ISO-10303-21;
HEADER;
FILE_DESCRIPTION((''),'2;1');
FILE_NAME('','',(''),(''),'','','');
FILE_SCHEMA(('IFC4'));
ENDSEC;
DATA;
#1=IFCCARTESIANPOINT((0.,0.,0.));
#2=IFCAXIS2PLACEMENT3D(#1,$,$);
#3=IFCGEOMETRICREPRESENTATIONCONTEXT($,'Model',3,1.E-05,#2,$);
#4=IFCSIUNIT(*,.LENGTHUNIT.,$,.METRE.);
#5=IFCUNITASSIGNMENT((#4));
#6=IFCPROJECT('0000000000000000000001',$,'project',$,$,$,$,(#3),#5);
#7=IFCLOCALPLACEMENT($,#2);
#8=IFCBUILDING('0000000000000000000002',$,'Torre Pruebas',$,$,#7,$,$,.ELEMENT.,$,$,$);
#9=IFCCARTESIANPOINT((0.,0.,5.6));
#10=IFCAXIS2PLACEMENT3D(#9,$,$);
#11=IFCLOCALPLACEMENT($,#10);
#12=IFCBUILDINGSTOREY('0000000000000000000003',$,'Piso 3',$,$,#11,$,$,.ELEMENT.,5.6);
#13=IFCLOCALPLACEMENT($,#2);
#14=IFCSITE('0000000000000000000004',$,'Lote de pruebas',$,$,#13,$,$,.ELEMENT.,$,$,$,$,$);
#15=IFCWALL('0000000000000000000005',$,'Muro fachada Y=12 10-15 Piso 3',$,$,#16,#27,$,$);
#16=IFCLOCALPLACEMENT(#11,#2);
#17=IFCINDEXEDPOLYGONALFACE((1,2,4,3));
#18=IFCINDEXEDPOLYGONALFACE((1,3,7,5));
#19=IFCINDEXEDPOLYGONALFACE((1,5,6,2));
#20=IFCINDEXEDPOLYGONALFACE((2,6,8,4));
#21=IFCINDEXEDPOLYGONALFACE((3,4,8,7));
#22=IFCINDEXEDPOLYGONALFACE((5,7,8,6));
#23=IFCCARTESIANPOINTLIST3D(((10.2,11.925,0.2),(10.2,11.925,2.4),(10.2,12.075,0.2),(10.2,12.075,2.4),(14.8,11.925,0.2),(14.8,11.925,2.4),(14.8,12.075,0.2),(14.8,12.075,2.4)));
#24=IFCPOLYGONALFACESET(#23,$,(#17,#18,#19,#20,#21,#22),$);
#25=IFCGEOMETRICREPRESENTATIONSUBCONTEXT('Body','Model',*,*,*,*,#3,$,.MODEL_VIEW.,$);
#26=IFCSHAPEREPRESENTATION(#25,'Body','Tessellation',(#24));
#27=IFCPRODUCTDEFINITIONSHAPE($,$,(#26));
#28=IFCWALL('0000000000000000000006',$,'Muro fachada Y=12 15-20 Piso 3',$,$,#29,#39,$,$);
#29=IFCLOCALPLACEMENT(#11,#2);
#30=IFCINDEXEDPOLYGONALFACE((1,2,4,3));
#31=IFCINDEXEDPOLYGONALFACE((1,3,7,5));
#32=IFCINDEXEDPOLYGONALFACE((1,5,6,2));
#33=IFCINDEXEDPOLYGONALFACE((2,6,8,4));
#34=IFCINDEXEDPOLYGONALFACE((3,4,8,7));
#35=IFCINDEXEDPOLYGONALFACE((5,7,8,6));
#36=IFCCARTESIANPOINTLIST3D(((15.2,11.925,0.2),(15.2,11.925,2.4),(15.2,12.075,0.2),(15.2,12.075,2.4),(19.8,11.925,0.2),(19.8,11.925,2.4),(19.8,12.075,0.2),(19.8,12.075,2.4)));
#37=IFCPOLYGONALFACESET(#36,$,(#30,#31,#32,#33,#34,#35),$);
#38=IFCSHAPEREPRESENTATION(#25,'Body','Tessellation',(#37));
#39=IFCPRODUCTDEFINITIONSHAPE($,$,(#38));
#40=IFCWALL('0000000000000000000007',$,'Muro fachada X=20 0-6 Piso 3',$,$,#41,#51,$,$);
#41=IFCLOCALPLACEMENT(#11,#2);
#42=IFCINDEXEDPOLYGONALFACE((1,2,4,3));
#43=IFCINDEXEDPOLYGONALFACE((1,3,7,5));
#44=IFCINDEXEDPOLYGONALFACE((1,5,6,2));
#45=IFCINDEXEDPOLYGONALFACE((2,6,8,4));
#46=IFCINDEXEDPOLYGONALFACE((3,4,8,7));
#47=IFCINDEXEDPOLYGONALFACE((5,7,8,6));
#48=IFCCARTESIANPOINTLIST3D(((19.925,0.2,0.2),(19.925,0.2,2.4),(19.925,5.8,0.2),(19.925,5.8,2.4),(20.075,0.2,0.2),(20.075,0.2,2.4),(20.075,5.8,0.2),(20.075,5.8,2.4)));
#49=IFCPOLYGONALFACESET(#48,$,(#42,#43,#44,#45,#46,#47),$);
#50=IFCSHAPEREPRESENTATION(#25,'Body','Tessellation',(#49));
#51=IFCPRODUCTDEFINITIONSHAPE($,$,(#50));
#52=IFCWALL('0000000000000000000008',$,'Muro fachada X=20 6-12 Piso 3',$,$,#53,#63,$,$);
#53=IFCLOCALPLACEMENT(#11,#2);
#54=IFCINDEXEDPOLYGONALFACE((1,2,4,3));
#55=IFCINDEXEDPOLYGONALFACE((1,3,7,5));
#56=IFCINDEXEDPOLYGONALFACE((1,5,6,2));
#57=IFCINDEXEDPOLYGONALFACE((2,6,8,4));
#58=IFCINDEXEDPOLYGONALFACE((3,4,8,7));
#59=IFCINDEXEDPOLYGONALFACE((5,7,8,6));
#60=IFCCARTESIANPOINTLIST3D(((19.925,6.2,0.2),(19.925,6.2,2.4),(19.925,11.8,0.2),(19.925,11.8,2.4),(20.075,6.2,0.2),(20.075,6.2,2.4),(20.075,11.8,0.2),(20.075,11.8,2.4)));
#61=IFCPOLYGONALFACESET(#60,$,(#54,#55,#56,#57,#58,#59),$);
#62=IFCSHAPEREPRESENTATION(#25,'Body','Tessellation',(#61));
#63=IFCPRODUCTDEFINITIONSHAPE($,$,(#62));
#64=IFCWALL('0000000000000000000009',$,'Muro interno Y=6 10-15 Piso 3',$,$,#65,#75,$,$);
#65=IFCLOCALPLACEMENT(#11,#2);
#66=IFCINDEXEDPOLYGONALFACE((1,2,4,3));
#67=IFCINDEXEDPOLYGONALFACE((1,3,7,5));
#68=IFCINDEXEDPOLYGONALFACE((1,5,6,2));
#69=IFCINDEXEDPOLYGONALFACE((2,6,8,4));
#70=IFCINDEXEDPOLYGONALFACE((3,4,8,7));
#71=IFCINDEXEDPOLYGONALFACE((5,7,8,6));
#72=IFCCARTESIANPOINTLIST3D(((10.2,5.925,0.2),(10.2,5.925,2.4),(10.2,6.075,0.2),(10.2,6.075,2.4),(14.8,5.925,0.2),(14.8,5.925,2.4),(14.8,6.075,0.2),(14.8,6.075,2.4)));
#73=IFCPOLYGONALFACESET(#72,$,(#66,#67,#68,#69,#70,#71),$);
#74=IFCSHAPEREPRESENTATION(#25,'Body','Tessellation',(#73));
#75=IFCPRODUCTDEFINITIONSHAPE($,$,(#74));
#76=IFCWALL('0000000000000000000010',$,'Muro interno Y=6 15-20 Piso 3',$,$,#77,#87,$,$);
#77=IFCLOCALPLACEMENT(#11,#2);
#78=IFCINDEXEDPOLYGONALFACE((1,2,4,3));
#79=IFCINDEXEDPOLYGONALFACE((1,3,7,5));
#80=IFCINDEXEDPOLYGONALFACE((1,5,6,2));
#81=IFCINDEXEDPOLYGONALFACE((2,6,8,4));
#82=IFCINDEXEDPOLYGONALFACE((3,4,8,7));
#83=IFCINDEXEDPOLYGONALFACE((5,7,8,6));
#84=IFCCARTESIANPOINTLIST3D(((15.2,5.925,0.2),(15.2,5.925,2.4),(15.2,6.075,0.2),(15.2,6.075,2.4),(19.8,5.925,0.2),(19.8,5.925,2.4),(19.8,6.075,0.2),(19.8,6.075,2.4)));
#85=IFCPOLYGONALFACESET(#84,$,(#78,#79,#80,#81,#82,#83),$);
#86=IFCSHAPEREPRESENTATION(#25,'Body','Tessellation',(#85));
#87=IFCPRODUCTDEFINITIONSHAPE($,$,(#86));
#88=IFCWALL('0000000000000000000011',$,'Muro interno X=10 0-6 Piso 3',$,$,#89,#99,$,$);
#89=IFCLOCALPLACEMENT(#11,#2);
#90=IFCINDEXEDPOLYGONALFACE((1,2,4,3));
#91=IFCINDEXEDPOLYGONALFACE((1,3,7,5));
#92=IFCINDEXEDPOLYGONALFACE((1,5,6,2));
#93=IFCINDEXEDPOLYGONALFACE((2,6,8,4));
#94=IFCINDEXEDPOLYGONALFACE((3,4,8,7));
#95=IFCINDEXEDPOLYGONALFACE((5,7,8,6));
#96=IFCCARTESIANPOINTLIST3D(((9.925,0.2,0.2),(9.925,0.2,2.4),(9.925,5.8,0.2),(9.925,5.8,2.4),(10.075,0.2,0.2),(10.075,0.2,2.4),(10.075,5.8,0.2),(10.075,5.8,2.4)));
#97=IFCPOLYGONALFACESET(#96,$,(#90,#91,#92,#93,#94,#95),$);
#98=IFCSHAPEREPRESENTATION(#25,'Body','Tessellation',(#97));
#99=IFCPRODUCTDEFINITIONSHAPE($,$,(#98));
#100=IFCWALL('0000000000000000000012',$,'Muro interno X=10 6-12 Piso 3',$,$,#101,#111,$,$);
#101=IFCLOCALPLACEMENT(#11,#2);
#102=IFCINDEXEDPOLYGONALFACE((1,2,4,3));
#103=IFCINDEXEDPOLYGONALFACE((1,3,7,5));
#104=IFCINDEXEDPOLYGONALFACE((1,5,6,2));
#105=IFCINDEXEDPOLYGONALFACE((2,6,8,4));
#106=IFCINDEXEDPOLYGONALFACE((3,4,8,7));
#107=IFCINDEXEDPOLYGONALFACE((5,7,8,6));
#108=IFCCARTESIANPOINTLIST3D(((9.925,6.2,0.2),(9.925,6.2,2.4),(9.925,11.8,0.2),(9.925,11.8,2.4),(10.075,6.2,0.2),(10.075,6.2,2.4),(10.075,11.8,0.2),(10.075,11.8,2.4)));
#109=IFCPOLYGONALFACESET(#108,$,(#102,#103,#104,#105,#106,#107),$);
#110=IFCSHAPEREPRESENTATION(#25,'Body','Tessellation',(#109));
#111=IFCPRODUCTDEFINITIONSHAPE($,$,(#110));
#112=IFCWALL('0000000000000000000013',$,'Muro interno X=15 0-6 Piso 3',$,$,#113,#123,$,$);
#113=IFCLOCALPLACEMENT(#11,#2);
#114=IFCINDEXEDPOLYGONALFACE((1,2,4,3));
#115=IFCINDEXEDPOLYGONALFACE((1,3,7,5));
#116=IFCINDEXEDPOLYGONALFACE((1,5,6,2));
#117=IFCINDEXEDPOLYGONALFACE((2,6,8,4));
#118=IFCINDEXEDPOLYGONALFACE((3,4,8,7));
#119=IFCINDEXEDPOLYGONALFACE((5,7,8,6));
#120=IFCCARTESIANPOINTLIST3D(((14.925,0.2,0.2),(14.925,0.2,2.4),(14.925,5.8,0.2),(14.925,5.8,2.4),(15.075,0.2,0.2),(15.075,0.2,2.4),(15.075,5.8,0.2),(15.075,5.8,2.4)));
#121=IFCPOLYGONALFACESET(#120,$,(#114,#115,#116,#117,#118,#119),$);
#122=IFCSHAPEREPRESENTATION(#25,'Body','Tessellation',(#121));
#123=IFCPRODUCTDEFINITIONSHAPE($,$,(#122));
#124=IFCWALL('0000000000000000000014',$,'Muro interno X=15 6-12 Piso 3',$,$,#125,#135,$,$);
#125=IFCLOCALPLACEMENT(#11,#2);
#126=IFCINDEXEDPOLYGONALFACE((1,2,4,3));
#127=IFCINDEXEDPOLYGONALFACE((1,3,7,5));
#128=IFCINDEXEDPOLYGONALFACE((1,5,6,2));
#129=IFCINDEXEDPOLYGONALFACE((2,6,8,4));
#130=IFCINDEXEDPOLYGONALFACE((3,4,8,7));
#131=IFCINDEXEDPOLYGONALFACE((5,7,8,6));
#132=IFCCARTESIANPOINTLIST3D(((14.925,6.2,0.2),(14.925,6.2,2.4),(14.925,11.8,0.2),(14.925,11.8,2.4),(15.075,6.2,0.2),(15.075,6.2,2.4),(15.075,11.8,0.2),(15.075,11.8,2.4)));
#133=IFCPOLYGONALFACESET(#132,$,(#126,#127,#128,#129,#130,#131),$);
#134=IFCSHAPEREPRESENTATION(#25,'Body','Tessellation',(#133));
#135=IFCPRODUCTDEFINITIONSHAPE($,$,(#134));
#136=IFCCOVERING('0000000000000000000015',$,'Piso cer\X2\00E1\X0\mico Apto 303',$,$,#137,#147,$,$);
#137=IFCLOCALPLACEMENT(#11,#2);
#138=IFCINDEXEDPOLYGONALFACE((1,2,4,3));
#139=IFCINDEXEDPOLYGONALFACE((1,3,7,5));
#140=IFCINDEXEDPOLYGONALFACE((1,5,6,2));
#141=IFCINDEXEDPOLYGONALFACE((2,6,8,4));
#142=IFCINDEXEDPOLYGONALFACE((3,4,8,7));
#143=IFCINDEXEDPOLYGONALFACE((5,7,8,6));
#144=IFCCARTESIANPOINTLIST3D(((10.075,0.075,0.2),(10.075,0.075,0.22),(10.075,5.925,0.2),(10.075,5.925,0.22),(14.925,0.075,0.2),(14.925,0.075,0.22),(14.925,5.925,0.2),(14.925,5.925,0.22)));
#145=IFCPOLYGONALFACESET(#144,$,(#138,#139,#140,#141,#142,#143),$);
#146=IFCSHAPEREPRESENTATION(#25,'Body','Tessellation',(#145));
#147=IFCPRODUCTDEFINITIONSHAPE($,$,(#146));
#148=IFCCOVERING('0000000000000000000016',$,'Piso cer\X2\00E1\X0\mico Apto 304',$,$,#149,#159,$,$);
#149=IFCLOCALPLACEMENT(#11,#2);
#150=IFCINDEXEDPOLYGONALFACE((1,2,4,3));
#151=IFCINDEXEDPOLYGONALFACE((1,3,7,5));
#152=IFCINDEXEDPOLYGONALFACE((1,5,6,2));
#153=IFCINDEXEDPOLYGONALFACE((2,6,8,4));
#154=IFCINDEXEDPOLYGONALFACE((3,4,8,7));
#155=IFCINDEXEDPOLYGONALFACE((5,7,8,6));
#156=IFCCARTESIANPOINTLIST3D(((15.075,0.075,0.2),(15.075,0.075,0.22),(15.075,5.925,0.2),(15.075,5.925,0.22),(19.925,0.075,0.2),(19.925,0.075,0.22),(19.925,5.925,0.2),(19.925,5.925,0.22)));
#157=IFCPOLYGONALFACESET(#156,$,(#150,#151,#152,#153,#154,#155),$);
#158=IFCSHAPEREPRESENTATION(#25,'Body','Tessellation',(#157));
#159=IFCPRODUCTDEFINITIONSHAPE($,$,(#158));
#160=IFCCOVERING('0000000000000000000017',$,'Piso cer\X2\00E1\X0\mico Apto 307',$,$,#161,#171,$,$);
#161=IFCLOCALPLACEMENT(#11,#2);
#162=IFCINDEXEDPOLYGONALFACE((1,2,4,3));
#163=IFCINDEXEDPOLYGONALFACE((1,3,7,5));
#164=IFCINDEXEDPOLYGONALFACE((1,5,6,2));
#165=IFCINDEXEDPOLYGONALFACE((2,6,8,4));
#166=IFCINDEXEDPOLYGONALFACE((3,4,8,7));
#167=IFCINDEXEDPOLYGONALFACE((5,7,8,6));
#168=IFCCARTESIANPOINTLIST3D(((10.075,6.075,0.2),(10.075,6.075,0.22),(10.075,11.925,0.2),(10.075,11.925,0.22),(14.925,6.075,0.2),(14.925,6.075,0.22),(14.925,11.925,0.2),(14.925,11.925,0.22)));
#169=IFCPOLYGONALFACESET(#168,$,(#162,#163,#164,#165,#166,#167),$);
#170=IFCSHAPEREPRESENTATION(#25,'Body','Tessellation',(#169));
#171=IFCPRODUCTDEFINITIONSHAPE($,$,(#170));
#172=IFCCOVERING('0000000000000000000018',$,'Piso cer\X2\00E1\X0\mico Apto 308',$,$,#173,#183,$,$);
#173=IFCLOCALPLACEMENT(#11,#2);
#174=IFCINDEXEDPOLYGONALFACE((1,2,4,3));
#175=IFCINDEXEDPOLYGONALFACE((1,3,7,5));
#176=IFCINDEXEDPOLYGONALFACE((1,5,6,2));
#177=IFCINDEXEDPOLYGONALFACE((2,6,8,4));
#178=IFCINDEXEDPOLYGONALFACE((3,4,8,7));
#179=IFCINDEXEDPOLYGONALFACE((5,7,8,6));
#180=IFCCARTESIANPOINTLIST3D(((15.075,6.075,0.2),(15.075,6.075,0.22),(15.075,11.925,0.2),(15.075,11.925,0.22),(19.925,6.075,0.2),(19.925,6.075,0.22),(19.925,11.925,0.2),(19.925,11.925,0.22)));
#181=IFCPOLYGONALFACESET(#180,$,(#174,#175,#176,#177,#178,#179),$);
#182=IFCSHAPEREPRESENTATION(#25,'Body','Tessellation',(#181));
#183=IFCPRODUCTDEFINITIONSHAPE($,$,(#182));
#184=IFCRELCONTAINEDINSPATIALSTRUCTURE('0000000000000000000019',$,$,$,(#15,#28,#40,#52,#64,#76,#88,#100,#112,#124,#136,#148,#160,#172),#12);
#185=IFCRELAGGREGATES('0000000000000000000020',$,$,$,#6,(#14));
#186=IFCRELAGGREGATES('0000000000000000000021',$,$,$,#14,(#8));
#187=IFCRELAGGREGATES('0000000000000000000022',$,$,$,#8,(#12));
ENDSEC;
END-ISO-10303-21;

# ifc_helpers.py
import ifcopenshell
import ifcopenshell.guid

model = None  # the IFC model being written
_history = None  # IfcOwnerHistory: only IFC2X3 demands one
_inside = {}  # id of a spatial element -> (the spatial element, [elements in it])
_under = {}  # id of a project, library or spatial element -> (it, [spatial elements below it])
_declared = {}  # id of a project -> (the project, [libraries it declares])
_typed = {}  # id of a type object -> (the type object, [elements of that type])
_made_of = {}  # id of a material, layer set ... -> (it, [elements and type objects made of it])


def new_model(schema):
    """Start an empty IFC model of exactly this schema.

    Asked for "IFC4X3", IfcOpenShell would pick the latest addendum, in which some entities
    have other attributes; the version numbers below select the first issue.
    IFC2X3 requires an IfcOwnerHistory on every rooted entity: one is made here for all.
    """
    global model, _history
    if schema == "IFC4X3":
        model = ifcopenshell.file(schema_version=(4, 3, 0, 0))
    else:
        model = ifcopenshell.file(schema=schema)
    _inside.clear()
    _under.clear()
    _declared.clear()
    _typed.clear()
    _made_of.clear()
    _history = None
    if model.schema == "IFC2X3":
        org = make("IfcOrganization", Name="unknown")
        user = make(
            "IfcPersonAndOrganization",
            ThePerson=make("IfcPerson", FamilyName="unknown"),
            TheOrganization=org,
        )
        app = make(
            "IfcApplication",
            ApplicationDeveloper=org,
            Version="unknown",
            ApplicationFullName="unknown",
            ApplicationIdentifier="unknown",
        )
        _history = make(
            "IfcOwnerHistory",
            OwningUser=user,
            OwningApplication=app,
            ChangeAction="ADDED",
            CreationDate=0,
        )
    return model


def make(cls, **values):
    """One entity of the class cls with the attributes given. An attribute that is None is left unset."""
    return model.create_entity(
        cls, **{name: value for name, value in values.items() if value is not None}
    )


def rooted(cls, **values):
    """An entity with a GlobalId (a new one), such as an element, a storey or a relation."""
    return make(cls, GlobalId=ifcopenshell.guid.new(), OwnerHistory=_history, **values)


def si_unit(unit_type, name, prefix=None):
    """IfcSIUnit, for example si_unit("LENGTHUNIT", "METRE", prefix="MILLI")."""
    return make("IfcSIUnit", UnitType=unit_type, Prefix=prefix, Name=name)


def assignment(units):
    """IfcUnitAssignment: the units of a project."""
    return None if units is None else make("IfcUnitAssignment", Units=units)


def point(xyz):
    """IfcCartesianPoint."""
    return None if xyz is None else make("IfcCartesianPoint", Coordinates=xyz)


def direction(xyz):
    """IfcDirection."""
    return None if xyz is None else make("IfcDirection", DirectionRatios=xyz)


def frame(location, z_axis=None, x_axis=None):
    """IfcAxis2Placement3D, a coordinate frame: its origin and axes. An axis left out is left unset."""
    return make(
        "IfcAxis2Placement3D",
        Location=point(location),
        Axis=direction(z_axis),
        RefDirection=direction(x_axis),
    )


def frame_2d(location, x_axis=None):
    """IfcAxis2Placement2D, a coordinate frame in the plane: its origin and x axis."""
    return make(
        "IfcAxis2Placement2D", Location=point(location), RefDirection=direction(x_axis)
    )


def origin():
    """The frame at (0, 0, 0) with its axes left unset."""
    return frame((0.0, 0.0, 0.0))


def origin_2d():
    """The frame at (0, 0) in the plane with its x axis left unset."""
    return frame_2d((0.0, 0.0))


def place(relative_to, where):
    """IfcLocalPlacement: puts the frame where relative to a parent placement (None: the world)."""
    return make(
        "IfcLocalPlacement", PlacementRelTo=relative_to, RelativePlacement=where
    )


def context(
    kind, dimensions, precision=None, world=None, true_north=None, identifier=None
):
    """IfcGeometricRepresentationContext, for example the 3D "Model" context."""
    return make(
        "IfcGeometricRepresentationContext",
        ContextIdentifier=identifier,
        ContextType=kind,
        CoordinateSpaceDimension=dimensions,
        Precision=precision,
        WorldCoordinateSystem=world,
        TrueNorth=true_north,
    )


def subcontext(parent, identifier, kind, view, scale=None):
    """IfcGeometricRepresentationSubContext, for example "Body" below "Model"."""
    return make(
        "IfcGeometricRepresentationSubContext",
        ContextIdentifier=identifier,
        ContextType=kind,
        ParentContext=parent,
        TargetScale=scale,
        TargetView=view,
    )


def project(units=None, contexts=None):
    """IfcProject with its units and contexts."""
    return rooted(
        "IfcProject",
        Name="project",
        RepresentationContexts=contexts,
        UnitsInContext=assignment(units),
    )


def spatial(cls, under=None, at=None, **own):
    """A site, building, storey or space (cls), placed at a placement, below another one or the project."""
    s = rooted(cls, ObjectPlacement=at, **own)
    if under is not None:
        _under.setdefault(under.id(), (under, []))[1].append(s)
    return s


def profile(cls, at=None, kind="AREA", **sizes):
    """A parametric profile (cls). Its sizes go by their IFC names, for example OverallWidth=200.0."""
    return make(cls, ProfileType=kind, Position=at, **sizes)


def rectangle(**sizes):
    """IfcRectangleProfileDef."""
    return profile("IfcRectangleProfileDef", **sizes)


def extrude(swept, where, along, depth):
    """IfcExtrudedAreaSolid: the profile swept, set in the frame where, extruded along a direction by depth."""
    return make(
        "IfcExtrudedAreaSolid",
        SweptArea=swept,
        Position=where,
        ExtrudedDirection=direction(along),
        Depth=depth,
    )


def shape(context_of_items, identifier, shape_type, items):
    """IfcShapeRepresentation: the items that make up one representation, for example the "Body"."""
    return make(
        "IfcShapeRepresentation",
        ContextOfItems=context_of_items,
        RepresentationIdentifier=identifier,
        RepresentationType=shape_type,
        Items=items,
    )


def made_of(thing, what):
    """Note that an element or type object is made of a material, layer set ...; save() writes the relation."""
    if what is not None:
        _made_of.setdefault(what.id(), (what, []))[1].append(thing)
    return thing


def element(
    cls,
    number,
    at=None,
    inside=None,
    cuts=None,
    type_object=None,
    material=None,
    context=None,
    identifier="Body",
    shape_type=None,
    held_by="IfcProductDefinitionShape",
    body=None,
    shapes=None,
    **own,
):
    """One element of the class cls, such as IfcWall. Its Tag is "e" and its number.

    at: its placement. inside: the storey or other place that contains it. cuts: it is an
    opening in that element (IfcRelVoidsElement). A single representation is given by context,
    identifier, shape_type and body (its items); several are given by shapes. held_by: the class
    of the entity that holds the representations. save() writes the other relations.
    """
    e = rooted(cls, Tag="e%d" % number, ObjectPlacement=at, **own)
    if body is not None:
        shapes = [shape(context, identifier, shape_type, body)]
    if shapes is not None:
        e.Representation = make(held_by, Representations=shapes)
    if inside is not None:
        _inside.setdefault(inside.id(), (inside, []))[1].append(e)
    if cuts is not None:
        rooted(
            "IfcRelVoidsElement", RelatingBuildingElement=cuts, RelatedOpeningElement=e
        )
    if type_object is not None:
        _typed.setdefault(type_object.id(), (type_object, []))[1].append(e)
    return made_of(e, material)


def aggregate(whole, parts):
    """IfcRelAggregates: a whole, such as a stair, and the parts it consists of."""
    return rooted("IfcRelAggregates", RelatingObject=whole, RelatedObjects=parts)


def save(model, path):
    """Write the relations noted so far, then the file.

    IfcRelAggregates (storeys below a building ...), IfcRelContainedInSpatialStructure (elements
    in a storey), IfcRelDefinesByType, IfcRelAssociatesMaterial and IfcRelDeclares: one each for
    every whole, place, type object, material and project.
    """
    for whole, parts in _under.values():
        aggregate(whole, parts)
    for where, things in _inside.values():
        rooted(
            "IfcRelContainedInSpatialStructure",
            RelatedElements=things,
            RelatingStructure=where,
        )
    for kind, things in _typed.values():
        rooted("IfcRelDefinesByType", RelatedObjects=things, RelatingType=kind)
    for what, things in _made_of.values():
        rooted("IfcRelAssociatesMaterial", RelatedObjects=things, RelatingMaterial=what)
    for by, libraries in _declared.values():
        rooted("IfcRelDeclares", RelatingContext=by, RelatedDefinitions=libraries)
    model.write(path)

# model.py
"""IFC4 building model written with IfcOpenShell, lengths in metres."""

from ifc_helpers import new_model, si_unit, frame, origin, origin_2d, place, context, subcontext, project, spatial, rectangle, extrude, element, save


model = new_model("IFC4")

# Units and contexts
model_context = context("Model", 3, precision=1e-05, world=origin())
body_context = subcontext(model_context, "Body", "Model", "MODEL_VIEW")
ifc_project = project(units=[si_unit("LENGTHUNIT", "METRE")], contexts=[model_context])

# Site, building, storey
site_placement = place(None, origin())
site = spatial("IfcSite", under=ifc_project, at=site_placement, Name="Lote de pruebas", CompositionType="ELEMENT")
building_placement = place(None, origin())
building = spatial("IfcBuilding", under=site, at=building_placement, Name="Torre Pruebas", CompositionType="ELEMENT")
storey_placement = place(None, frame((0.0, 0.0, 5.6)))
storey = spatial("IfcBuildingStorey", under=building, at=storey_placement, Name="Piso 3", CompositionType="ELEMENT", Elevation=5.6)

# Walls
for number, where, name in (
    (1, (12.5, 12.0, 5.8), "Muro fachada Y=12 10-15 Piso 3"),
    (2, (17.5, 12.0, 5.8), "Muro fachada Y=12 15-20 Piso 3"),
):
    element("IfcWall", number, at=place(None, frame(where)), inside=storey, Name=name, context=body_context, shape_type="SweptSolid", body=[
        extrude(rectangle(XDim=4.6, YDim=0.15, at=origin_2d()), origin(), (0.0, 0.0, 1.0), 2.2),
    ])
for number, where, name in (
    (3, (20.0, 3.0, 5.8), "Muro fachada X=20 0-6 Piso 3"),
    (4, (20.0, 9.0, 5.8), "Muro fachada X=20 6-12 Piso 3"),
):
    element("IfcWall", number, at=place(None, frame(where)), inside=storey, Name=name, context=body_context, shape_type="SweptSolid", body=[
        extrude(rectangle(XDim=0.15, YDim=5.6, at=origin_2d()), origin(), (0.0, 0.0, 1.0), 2.2),
    ])
for number, where, name in (
    (5, (12.5, 6.0, 5.8), "Muro interno Y=6 10-15 Piso 3"),
    (6, (17.5, 6.0, 5.8), "Muro interno Y=6 15-20 Piso 3"),
):
    element("IfcWall", number, at=place(None, frame(where)), inside=storey, Name=name, context=body_context, shape_type="SweptSolid", body=[
        extrude(rectangle(XDim=4.6, YDim=0.15, at=origin_2d()), origin(), (0.0, 0.0, 1.0), 2.2),
    ])
for number, where, name in (
    (7, (10.0, 3.0, 5.8), "Muro interno X=10 0-6 Piso 3"),
    (8, (10.0, 9.0, 5.8), "Muro interno X=10 6-12 Piso 3"),
    (9, (15.0, 3.0, 5.8), "Muro interno X=15 0-6 Piso 3"),
    (10, (15.0, 9.0, 5.8), "Muro interno X=15 6-12 Piso 3"),
):
    element("IfcWall", number, at=place(None, frame(where)), inside=storey, Name=name, context=body_context, shape_type="SweptSolid", body=[
        extrude(rectangle(XDim=0.15, YDim=5.6, at=origin_2d()), origin(), (0.0, 0.0, 1.0), 2.2),
    ])

# Coverings
for number, where, name in (
    (11, (12.5, 3.0, 5.8), "Piso cerámico Apto 303"),
    (12, (17.5, 3.0, 5.8), "Piso cerámico Apto 304"),
    (13, (12.5, 9.0, 5.8), "Piso cerámico Apto 307"),
    (14, (17.5, 9.0, 5.8), "Piso cerámico Apto 308"),
):
    element("IfcCovering", number, at=place(None, frame(where)), inside=storey, Name=name, context=body_context, shape_type="SweptSolid", body=[
        extrude(rectangle(XDim=4.85, YDim=5.85, at=origin_2d()), origin(), (0.0, 0.0, 1.0), 0.02),
    ])

save(model, "model.ifc")
